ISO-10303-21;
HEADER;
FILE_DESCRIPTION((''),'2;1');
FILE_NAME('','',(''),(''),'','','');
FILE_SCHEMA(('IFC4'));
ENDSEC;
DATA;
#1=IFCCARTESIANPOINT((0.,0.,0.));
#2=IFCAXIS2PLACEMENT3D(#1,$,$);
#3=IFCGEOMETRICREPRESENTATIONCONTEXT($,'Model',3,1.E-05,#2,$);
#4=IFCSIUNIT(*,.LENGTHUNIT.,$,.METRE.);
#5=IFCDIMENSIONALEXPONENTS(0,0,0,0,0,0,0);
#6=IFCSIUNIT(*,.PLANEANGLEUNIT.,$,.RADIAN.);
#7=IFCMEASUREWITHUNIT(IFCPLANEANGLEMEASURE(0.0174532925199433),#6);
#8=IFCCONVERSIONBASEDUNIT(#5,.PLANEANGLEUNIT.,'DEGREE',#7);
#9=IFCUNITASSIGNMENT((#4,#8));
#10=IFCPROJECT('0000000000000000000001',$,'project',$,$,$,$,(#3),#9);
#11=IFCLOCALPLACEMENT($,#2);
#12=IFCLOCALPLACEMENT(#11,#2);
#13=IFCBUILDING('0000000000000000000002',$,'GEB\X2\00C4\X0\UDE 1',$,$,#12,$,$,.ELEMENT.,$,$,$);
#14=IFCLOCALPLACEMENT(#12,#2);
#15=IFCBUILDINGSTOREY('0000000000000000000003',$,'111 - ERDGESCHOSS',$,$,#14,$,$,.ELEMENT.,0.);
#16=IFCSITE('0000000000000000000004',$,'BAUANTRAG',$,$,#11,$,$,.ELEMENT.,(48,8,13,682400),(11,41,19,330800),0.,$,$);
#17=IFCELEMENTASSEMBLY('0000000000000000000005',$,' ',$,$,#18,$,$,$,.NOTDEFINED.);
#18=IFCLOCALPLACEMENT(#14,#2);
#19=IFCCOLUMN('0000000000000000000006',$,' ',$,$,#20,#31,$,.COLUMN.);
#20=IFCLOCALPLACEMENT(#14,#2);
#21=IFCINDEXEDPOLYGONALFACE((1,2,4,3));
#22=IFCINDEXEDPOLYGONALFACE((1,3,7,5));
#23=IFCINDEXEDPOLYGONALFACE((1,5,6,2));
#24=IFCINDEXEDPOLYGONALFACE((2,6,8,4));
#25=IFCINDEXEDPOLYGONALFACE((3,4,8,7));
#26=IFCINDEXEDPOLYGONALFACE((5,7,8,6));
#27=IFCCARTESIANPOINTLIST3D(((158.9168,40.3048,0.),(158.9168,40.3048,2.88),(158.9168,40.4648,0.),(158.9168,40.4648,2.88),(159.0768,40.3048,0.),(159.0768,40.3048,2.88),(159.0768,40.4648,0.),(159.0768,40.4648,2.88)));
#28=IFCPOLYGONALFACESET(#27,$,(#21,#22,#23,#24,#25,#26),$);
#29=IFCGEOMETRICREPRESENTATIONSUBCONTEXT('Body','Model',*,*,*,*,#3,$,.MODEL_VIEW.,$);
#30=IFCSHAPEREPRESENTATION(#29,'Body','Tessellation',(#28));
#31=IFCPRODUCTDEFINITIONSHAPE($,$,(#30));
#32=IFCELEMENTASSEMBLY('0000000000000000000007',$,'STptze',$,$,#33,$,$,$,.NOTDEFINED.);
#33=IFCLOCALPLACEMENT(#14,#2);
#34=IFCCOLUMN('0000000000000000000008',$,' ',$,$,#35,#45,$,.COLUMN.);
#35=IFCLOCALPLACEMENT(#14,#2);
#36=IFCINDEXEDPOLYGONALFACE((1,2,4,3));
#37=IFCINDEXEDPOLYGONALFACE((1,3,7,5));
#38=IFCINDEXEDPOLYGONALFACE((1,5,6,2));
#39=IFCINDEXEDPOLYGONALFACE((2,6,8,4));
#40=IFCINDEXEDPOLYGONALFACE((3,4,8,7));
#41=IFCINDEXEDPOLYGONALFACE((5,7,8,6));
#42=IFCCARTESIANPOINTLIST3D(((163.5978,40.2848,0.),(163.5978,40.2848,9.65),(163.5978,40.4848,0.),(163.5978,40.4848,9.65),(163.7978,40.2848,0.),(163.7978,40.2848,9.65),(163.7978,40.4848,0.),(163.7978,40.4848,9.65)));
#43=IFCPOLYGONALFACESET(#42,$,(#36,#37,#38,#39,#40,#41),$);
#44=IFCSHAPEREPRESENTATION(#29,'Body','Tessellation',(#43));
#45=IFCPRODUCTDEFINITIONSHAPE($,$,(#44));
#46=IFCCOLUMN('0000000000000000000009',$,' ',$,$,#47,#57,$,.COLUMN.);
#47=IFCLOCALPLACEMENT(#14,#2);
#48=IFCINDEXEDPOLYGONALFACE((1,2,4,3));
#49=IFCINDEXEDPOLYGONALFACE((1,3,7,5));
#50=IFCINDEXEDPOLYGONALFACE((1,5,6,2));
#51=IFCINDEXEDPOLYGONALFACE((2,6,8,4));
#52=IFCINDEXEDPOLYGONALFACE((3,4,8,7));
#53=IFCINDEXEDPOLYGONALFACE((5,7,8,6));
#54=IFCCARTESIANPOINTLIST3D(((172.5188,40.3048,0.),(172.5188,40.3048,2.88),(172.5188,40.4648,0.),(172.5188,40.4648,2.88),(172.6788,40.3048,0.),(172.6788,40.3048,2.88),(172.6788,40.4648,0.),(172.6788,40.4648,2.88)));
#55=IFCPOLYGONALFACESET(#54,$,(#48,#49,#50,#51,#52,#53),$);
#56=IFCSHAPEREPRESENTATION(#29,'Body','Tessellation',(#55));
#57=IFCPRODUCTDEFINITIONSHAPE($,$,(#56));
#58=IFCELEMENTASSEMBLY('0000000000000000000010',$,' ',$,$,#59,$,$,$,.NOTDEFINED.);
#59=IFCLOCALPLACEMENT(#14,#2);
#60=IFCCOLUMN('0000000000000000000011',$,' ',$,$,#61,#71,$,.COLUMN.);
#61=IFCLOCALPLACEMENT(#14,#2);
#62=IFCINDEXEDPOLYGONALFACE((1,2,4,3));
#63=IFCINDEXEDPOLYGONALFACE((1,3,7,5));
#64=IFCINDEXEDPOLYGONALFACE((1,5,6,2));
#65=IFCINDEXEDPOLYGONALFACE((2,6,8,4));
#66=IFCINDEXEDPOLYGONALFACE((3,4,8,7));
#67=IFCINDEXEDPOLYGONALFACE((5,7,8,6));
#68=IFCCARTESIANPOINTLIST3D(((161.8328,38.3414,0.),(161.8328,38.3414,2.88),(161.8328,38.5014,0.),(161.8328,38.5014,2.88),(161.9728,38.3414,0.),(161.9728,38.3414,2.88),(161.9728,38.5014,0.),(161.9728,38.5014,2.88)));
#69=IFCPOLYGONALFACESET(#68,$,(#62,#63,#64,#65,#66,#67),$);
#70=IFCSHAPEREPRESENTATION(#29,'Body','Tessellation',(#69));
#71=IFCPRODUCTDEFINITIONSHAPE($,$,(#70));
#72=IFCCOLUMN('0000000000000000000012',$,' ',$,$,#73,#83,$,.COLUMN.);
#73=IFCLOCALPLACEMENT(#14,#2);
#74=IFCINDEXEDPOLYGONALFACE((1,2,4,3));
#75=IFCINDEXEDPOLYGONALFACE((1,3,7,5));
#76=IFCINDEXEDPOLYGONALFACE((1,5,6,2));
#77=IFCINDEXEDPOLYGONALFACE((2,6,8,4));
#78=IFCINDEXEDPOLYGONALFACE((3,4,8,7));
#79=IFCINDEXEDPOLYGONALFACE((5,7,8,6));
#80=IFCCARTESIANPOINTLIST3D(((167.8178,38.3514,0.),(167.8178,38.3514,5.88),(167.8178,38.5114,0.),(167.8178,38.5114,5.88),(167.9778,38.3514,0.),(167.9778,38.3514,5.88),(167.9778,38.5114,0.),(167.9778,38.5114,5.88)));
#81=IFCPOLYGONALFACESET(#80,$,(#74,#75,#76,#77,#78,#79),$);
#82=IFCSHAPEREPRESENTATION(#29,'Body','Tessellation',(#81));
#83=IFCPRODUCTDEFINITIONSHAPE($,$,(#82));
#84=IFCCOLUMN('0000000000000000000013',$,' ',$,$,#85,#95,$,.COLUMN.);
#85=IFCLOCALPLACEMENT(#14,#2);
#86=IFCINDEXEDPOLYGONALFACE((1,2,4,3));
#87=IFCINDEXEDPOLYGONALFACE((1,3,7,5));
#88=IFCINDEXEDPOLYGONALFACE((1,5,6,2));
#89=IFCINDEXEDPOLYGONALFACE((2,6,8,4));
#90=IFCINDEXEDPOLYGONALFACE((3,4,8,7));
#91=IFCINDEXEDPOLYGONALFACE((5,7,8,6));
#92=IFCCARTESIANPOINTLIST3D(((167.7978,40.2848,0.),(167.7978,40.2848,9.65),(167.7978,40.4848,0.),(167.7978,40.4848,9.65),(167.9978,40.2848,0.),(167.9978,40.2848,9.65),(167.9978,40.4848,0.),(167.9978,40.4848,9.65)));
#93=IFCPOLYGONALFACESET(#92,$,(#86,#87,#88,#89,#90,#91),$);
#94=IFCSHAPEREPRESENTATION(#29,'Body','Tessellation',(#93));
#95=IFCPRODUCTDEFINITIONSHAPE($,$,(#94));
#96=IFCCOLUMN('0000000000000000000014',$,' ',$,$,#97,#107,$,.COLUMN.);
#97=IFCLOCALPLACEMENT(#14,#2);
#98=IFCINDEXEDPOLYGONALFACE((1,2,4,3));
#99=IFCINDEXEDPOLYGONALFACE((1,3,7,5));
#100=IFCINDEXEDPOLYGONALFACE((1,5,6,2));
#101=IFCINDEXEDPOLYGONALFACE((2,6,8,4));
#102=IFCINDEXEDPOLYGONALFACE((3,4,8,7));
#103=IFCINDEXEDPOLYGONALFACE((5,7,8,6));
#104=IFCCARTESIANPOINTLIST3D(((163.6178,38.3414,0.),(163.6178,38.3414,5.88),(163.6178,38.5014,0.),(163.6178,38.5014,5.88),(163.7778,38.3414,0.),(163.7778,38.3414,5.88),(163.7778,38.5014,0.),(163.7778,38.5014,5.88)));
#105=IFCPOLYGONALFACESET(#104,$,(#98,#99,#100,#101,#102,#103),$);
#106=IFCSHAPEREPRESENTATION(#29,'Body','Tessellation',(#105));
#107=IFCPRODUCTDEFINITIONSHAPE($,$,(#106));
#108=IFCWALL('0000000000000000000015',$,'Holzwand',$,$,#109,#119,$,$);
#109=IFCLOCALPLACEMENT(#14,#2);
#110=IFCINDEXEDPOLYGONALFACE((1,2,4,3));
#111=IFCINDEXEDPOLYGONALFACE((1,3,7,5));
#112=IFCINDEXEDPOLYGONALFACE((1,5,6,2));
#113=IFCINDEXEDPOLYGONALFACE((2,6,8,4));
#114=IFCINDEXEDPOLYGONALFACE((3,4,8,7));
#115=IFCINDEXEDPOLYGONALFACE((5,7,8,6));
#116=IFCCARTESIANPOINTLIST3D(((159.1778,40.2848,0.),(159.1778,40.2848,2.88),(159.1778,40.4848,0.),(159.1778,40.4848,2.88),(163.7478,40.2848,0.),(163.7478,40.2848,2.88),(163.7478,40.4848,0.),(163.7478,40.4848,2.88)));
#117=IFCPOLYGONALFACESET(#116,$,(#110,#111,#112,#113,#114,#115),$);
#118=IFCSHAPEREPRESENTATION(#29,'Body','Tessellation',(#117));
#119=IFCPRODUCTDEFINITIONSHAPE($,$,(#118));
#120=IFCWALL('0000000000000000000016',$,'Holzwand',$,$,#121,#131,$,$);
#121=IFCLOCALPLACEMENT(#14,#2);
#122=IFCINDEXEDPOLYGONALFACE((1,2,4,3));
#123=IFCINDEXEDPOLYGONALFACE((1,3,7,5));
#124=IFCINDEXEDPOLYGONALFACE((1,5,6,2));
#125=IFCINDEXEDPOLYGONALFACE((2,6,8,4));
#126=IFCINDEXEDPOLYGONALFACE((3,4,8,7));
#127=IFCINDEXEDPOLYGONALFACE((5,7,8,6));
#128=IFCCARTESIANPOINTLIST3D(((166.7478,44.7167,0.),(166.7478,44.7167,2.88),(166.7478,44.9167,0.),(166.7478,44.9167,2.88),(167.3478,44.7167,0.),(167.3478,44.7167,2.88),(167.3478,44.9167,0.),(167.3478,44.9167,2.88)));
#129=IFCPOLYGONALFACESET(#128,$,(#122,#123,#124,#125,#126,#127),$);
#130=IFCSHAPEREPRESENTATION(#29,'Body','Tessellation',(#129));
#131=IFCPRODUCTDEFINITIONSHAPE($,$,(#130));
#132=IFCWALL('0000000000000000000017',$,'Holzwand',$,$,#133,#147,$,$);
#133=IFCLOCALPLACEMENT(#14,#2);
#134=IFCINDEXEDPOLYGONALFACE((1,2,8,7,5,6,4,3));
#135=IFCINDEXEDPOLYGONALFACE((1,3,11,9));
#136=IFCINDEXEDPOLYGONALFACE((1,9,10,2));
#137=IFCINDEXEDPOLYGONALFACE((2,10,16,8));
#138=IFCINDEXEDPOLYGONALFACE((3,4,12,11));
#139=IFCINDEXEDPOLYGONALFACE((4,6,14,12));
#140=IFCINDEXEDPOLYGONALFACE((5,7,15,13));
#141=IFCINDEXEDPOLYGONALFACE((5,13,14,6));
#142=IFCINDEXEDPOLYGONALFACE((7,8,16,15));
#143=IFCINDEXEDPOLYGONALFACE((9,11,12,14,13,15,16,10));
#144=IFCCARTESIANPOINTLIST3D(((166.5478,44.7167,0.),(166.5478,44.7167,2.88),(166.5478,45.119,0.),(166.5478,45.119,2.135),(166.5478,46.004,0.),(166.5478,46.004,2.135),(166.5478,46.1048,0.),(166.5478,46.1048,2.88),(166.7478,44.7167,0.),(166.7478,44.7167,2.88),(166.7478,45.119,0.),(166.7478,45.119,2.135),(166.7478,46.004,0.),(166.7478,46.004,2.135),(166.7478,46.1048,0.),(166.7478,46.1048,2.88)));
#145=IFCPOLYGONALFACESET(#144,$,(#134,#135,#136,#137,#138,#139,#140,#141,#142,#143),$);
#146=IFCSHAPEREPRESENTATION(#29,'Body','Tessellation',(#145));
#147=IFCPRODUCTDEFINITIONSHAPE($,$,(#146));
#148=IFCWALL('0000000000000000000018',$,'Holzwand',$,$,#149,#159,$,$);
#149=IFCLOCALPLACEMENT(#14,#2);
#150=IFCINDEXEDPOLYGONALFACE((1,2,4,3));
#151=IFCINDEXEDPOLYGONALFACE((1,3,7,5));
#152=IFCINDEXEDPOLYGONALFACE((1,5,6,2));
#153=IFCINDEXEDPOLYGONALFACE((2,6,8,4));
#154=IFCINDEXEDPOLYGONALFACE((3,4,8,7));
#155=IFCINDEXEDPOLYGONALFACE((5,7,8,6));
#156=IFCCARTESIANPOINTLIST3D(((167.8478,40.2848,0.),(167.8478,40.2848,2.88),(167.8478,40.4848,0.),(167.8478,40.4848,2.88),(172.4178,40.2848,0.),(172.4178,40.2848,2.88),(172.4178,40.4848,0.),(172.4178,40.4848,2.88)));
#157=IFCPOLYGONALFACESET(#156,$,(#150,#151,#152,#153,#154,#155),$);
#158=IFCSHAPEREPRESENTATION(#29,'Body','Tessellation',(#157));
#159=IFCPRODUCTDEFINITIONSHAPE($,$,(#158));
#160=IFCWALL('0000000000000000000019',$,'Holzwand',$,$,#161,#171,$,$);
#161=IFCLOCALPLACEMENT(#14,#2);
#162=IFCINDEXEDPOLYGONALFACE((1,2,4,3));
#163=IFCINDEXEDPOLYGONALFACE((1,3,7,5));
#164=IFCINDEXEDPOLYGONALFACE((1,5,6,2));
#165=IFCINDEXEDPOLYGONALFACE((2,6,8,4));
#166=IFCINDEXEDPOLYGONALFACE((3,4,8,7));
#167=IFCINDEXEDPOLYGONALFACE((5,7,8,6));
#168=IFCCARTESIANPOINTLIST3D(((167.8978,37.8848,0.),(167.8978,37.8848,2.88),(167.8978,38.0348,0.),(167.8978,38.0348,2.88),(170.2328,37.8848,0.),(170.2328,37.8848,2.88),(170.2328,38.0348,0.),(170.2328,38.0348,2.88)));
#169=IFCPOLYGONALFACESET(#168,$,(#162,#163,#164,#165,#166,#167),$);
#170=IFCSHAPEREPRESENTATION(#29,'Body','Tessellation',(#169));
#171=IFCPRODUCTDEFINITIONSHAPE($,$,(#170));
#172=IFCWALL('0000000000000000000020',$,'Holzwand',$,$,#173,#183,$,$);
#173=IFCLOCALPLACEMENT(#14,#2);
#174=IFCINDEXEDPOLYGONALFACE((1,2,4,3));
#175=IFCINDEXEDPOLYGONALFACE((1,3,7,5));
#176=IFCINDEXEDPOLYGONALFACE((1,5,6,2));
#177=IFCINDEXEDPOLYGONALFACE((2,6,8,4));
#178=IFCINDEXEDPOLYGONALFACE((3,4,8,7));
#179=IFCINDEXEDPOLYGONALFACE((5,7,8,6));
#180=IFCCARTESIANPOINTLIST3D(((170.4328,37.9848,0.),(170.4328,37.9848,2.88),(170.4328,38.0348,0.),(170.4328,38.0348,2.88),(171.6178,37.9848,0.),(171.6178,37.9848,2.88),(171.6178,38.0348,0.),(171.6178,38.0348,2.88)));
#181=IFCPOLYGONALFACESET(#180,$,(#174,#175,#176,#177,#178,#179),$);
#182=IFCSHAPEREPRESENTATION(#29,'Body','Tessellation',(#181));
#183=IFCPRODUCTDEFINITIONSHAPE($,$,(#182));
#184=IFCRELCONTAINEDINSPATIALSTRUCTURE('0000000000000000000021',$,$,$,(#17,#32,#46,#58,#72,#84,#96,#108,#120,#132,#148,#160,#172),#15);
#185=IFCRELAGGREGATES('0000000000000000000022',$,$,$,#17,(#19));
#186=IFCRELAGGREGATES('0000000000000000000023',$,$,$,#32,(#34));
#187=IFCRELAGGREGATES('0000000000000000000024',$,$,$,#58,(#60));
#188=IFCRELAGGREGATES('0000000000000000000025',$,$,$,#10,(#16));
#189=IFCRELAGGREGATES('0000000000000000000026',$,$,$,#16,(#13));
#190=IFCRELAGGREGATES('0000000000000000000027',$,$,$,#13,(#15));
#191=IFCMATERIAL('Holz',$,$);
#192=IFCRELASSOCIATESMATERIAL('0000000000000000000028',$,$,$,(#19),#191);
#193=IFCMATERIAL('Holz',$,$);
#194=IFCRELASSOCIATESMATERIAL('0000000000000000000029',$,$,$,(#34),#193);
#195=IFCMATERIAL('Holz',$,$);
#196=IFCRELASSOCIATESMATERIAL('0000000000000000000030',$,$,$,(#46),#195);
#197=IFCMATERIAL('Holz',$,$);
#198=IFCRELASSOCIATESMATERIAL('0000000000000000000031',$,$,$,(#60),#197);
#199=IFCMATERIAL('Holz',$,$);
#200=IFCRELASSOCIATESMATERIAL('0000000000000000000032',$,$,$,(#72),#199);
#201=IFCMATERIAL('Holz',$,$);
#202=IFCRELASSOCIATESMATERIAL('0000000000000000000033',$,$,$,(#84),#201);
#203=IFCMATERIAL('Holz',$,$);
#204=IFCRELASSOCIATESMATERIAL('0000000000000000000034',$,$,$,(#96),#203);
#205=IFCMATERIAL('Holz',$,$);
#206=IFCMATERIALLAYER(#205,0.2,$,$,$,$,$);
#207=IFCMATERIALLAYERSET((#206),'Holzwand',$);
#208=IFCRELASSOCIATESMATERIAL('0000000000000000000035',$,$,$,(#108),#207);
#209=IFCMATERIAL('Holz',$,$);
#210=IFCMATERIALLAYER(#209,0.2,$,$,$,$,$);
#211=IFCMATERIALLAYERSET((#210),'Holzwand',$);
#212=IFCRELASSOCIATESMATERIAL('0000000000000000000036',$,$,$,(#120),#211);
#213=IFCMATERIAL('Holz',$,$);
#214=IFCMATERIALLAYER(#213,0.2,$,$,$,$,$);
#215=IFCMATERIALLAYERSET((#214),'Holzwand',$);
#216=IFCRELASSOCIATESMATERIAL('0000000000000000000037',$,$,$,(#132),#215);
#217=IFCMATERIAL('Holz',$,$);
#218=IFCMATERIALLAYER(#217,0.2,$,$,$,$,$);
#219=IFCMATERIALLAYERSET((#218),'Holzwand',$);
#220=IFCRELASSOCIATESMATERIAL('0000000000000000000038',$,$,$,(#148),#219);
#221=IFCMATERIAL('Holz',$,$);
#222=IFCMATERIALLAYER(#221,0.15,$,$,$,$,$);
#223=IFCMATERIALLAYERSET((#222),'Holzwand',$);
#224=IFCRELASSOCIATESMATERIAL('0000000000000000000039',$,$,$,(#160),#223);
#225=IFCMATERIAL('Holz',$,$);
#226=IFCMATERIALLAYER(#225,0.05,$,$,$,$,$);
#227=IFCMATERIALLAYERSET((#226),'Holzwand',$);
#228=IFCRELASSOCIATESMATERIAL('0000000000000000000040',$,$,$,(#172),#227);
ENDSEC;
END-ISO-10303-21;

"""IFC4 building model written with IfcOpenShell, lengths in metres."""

from ifc_helpers import new_model, entity, si_unit, converted_unit, frame, frame_2d, origin, origin_with_axes, place, context, subcontext, project, spatial, polyline, rectangle, outline, extrude, material, layer, layer_set, layer_usage, element, aggregate, save


model = new_model("IFC4")

# Units and contexts
model_context = context("Model", 3, precision=1e-05, world=origin())
body_context = subcontext(model_context, "Body", "Model", "MODEL_VIEW")
ifc_project = project(units=[si_unit("LENGTHUNIT", "METRE"), converted_unit("PLANEANGLEUNIT", "DEGREE", entity("IfcPlaneAngleMeasure", 0.0174532925199433), si_unit("PLANEANGLEUNIT", "RADIAN"), dimensions=[0, 0, 0, 0, 0, 0, 0])], contexts=[model_context])

# Site, building, storey
site_placement = place(None, origin())
site = spatial("IfcSite", under=ifc_project, at=site_placement, Name="BAUANTRAG", CompositionType="ELEMENT", RefLatitude=(48, 8, 13, 682400), RefLongitude=(11, 41, 19, 330800), RefElevation=0.0)
building_placement = place(site_placement, origin())
building = spatial("IfcBuilding", under=site, at=building_placement, Name="GEBÄUDE 1", CompositionType="ELEMENT")
storey_placement = place(building_placement, origin())
storey = spatial("IfcBuildingStorey", under=building, at=storey_placement, Name="111 - ERDGESCHOSS", CompositionType="ELEMENT", Elevation=0.0)

# Element assemblies, columns
assembly_1_placement = place(storey_placement, origin())
assembly_1 = element("IfcElementAssembly", 1, at=assembly_1_placement, inside=storey, Name=" ", PredefinedType="NOTDEFINED")
ifc_material_1 = material(Name="Holz")
column_1_placement = place(assembly_1_placement, frame((158.9168, 40.3048, 0.0)))
column_1 = element("IfcColumn", 2, at=column_1_placement, material=ifc_material_1, Name=" ", PredefinedType="COLUMN", context=body_context, shape_type="SweptSolid", body=[
    extrude(rectangle(XDim=0.16, YDim=0.16, at=frame_2d((0.08, 0.08), x_axis=(1.0, 0.0))), origin_with_axes(), (0.0, 0.0, 1.0), 2.88),
])
aggregate(assembly_1, [column_1])
assembly_2_placement = place(storey_placement, origin())
assembly_2 = element("IfcElementAssembly", 3, at=assembly_2_placement, inside=storey, Name="STptze", PredefinedType="NOTDEFINED")
ifc_material_2 = material(Name="Holz")
column_2_placement = place(assembly_2_placement, frame((163.5978, 40.2848, 0.0)))
column_2 = element("IfcColumn", 4, at=column_2_placement, material=ifc_material_2, Name=" ", PredefinedType="COLUMN", context=body_context, shape_type="SweptSolid", body=[
    extrude(rectangle(XDim=0.2, YDim=0.2, at=frame_2d((0.1, 0.1), x_axis=(1.0, 0.0))), origin_with_axes(), (0.0, 0.0, 1.0), 9.65),
])
aggregate(assembly_2, [column_2])

# Column
ifc_material_3 = material(Name="Holz")
column_3_placement = place(storey_placement, frame((172.5188, 40.3048, 0.0)))
element("IfcColumn", 5, at=column_3_placement, inside=storey, material=ifc_material_3, Name=" ", PredefinedType="COLUMN", context=body_context, shape_type="SweptSolid", body=[
    extrude(rectangle(XDim=0.16, YDim=0.16, at=frame_2d((0.08, 0.08), x_axis=(1.0, 0.0))), origin_with_axes(), (0.0, 0.0, 1.0), 2.88),
])

# Element assembly, column
assembly_3_placement = place(storey_placement, origin())
assembly_3 = element("IfcElementAssembly", 6, at=assembly_3_placement, inside=storey, Name=" ", PredefinedType="NOTDEFINED")
ifc_material_4 = material(Name="Holz")
column_4_placement = place(assembly_3_placement, frame((161.9728, 38.3414, 0.0)))
column_4 = element("IfcColumn", 7, at=column_4_placement, material=ifc_material_4, Name=" ", PredefinedType="COLUMN", context=body_context, shape_type="SweptSolid", body=[
    extrude(rectangle(XDim=0.16, YDim=0.14, at=frame_2d((-0.07, 0.08), x_axis=(0.0, 1.0))), origin_with_axes(), (0.0, 0.0, 1.0), 2.88),
])
aggregate(assembly_3, [column_4])

# Columns
ifc_material_5 = material(Name="Holz")
column_5_placement = place(storey_placement, frame((167.8178, 38.3514, 0.0)))
element("IfcColumn", 8, at=column_5_placement, inside=storey, material=ifc_material_5, Name=" ", PredefinedType="COLUMN", context=body_context, shape_type="SweptSolid", body=[
    extrude(rectangle(XDim=0.16, YDim=0.16, at=frame_2d((0.08, 0.08), x_axis=(1.0, 0.0))), origin_with_axes(), (0.0, 0.0, 1.0), 5.88),
])
ifc_material_6 = material(Name="Holz")
column_6_placement = place(storey_placement, frame((167.7978, 40.2848, 0.0)))
element("IfcColumn", 9, at=column_6_placement, inside=storey, material=ifc_material_6, Name=" ", PredefinedType="COLUMN", context=body_context, shape_type="SweptSolid", body=[
    extrude(rectangle(XDim=0.2, YDim=0.2, at=frame_2d((0.1, 0.1), x_axis=(1.0, 0.0))), origin_with_axes(), (0.0, 0.0, 1.0), 9.65),
])
ifc_material_7 = material(Name="Holz")
column_7_placement = place(storey_placement, frame((163.6178, 38.3414, 0.0)))
element("IfcColumn", 10, at=column_7_placement, inside=storey, material=ifc_material_7, Name=" ", PredefinedType="COLUMN", context=body_context, shape_type="SweptSolid", body=[
    extrude(rectangle(XDim=0.16, YDim=0.16, at=frame_2d((0.08, 0.08), x_axis=(1.0, 0.0))), origin_with_axes(), (0.0, 0.0, 1.0), 5.88),
])

# Walls
ifc_material_8 = material(Name="Holz")
ifc_layer_1 = layer(ifc_material_8, 0.2)
ifc_layer_set_1 = layer_set([ifc_layer_1], Name="Holzwand")
ifc_layer_usage_1 = layer_usage(ifc_layer_set_1, "AXIS2", "POSITIVE", 0.0)
wall_1_placement = place(storey_placement, frame((163.7478, 40.4848, 0.0), z_axis=(0.0, 0.0, 1.0), x_axis=(-1.0, 0.0, 0.0)))
element("IfcWall", 11, at=wall_1_placement, inside=storey, material=ifc_layer_usage_1, Name="Holzwand", context=body_context, shape_type="SweptSolid", body=[
    extrude(rectangle(XDim=4.57, YDim=0.2, at=frame_2d((2.285, 0.1), x_axis=(1.0, 0.0))), origin_with_axes(), (0.0, 0.0, 1.0), 2.88),
])
ifc_material_9 = material(Name="Holz")
ifc_layer_2 = layer(ifc_material_9, 0.2)
ifc_layer_set_2 = layer_set([ifc_layer_2], Name="Holzwand")
ifc_layer_usage_2 = layer_usage(ifc_layer_set_2, "AXIS2", "POSITIVE", 0.0)
wall_2_placement = place(storey_placement, frame((166.7478, 44.7167, 0.0)))
element("IfcWall", 12, at=wall_2_placement, inside=storey, material=ifc_layer_usage_2, Name="Holzwand", context=body_context, shape_type="SweptSolid", body=[
    extrude(rectangle(XDim=0.6, YDim=0.2, at=frame_2d((0.3, 0.1), x_axis=(1.0, 0.0))), origin_with_axes(), (0.0, 0.0, 1.0), 2.88),
])

# Wall, opening
ifc_material_10 = material(Name="Holz")
ifc_layer_3 = layer(ifc_material_10, 0.2)
ifc_layer_set_3 = layer_set([ifc_layer_3], Name="Holzwand")
ifc_layer_usage_3 = layer_usage(ifc_layer_set_3, "AXIS2", "POSITIVE", 0.0)
wall_3_placement = place(storey_placement, frame((166.5478, 46.1048, 0.0), z_axis=(0.0, 0.0, 1.0), x_axis=(0.0, -1.0, 0.0)))
wall_3 = element("IfcWall", 13, at=wall_3_placement, inside=storey, material=ifc_layer_usage_3, Name="Holzwand", context=body_context, shape_type="SweptSolid", body=[
    extrude(rectangle(XDim=1.3881, YDim=0.2, at=frame_2d((0.6941, 0.1), x_axis=(1.0, 0.0))), origin_with_axes(), (0.0, 0.0, 1.0), 2.88),
])
opening_1_placement = place(wall_3_placement, frame((0.9858, 0.2, 0.0), z_axis=(0.0, -1.0, 0.0), x_axis=(0.0, 0.0, 1.0)))
element("IfcOpeningElement", 14, at=opening_1_placement, cuts=wall_3, ObjectType="Opening", context=body_context, shape_type="SweptSolid", body=[
    extrude(outline(polyline([(0.0, 0.885), (2.135, 0.885), (2.135, 0.0), (0.0, 0.0), (0.0, 0.885)])), origin_with_axes(), (0.0, 0.0, 1.0), 0.2),
])

# Walls
ifc_material_11 = material(Name="Holz")
ifc_layer_4 = layer(ifc_material_11, 0.2)
ifc_layer_set_4 = layer_set([ifc_layer_4], Name="Holzwand")
ifc_layer_usage_4 = layer_usage(ifc_layer_set_4, "AXIS2", "POSITIVE", 0.0)
wall_4_placement = place(storey_placement, frame((172.4178, 40.4848, 0.0), z_axis=(0.0, 0.0, 1.0), x_axis=(-1.0, 0.0, 0.0)))
element("IfcWall", 15, at=wall_4_placement, inside=storey, material=ifc_layer_usage_4, Name="Holzwand", context=body_context, shape_type="SweptSolid", body=[
    extrude(rectangle(XDim=4.57, YDim=0.2, at=frame_2d((2.285, 0.1), x_axis=(1.0, 0.0))), origin_with_axes(), (0.0, 0.0, 1.0), 2.88),
])
ifc_material_12 = material(Name="Holz")
ifc_layer_5 = layer(ifc_material_12, 0.15)
ifc_layer_set_5 = layer_set([ifc_layer_5], Name="Holzwand")
ifc_layer_usage_5 = layer_usage(ifc_layer_set_5, "AXIS2", "POSITIVE", 0.0)
wall_5_placement = place(storey_placement, frame((170.2328, 38.0348, 0.0), z_axis=(0.0, 0.0, 1.0), x_axis=(-1.0, 0.0, 0.0)))
element("IfcWall", 16, at=wall_5_placement, inside=storey, material=ifc_layer_usage_5, Name="Holzwand", context=body_context, shape_type="SweptSolid", body=[
    extrude(rectangle(XDim=2.335, YDim=0.15, at=frame_2d((1.1675, 0.075), x_axis=(1.0, 0.0))), origin_with_axes(), (0.0, 0.0, 1.0), 2.88),
])
ifc_material_13 = material(Name="Holz")
ifc_layer_6 = layer(ifc_material_13, 0.05)
ifc_layer_set_6 = layer_set([ifc_layer_6], Name="Holzwand")
ifc_layer_usage_6 = layer_usage(ifc_layer_set_6, "AXIS2", "POSITIVE", 0.0)
wall_6_placement = place(storey_placement, frame((170.4328, 37.9848, 0.0)))
element("IfcWall", 17, at=wall_6_placement, inside=storey, material=ifc_layer_usage_6, Name="Holzwand", context=body_context, shape_type="SweptSolid", body=[
    extrude(rectangle(XDim=1.185, YDim=0.05, at=frame_2d((0.5925, 0.025), x_axis=(1.0, 0.0))), origin_with_axes(), (0.0, 0.0, 1.0), 2.88),
])

save(model, "model.ifc")
